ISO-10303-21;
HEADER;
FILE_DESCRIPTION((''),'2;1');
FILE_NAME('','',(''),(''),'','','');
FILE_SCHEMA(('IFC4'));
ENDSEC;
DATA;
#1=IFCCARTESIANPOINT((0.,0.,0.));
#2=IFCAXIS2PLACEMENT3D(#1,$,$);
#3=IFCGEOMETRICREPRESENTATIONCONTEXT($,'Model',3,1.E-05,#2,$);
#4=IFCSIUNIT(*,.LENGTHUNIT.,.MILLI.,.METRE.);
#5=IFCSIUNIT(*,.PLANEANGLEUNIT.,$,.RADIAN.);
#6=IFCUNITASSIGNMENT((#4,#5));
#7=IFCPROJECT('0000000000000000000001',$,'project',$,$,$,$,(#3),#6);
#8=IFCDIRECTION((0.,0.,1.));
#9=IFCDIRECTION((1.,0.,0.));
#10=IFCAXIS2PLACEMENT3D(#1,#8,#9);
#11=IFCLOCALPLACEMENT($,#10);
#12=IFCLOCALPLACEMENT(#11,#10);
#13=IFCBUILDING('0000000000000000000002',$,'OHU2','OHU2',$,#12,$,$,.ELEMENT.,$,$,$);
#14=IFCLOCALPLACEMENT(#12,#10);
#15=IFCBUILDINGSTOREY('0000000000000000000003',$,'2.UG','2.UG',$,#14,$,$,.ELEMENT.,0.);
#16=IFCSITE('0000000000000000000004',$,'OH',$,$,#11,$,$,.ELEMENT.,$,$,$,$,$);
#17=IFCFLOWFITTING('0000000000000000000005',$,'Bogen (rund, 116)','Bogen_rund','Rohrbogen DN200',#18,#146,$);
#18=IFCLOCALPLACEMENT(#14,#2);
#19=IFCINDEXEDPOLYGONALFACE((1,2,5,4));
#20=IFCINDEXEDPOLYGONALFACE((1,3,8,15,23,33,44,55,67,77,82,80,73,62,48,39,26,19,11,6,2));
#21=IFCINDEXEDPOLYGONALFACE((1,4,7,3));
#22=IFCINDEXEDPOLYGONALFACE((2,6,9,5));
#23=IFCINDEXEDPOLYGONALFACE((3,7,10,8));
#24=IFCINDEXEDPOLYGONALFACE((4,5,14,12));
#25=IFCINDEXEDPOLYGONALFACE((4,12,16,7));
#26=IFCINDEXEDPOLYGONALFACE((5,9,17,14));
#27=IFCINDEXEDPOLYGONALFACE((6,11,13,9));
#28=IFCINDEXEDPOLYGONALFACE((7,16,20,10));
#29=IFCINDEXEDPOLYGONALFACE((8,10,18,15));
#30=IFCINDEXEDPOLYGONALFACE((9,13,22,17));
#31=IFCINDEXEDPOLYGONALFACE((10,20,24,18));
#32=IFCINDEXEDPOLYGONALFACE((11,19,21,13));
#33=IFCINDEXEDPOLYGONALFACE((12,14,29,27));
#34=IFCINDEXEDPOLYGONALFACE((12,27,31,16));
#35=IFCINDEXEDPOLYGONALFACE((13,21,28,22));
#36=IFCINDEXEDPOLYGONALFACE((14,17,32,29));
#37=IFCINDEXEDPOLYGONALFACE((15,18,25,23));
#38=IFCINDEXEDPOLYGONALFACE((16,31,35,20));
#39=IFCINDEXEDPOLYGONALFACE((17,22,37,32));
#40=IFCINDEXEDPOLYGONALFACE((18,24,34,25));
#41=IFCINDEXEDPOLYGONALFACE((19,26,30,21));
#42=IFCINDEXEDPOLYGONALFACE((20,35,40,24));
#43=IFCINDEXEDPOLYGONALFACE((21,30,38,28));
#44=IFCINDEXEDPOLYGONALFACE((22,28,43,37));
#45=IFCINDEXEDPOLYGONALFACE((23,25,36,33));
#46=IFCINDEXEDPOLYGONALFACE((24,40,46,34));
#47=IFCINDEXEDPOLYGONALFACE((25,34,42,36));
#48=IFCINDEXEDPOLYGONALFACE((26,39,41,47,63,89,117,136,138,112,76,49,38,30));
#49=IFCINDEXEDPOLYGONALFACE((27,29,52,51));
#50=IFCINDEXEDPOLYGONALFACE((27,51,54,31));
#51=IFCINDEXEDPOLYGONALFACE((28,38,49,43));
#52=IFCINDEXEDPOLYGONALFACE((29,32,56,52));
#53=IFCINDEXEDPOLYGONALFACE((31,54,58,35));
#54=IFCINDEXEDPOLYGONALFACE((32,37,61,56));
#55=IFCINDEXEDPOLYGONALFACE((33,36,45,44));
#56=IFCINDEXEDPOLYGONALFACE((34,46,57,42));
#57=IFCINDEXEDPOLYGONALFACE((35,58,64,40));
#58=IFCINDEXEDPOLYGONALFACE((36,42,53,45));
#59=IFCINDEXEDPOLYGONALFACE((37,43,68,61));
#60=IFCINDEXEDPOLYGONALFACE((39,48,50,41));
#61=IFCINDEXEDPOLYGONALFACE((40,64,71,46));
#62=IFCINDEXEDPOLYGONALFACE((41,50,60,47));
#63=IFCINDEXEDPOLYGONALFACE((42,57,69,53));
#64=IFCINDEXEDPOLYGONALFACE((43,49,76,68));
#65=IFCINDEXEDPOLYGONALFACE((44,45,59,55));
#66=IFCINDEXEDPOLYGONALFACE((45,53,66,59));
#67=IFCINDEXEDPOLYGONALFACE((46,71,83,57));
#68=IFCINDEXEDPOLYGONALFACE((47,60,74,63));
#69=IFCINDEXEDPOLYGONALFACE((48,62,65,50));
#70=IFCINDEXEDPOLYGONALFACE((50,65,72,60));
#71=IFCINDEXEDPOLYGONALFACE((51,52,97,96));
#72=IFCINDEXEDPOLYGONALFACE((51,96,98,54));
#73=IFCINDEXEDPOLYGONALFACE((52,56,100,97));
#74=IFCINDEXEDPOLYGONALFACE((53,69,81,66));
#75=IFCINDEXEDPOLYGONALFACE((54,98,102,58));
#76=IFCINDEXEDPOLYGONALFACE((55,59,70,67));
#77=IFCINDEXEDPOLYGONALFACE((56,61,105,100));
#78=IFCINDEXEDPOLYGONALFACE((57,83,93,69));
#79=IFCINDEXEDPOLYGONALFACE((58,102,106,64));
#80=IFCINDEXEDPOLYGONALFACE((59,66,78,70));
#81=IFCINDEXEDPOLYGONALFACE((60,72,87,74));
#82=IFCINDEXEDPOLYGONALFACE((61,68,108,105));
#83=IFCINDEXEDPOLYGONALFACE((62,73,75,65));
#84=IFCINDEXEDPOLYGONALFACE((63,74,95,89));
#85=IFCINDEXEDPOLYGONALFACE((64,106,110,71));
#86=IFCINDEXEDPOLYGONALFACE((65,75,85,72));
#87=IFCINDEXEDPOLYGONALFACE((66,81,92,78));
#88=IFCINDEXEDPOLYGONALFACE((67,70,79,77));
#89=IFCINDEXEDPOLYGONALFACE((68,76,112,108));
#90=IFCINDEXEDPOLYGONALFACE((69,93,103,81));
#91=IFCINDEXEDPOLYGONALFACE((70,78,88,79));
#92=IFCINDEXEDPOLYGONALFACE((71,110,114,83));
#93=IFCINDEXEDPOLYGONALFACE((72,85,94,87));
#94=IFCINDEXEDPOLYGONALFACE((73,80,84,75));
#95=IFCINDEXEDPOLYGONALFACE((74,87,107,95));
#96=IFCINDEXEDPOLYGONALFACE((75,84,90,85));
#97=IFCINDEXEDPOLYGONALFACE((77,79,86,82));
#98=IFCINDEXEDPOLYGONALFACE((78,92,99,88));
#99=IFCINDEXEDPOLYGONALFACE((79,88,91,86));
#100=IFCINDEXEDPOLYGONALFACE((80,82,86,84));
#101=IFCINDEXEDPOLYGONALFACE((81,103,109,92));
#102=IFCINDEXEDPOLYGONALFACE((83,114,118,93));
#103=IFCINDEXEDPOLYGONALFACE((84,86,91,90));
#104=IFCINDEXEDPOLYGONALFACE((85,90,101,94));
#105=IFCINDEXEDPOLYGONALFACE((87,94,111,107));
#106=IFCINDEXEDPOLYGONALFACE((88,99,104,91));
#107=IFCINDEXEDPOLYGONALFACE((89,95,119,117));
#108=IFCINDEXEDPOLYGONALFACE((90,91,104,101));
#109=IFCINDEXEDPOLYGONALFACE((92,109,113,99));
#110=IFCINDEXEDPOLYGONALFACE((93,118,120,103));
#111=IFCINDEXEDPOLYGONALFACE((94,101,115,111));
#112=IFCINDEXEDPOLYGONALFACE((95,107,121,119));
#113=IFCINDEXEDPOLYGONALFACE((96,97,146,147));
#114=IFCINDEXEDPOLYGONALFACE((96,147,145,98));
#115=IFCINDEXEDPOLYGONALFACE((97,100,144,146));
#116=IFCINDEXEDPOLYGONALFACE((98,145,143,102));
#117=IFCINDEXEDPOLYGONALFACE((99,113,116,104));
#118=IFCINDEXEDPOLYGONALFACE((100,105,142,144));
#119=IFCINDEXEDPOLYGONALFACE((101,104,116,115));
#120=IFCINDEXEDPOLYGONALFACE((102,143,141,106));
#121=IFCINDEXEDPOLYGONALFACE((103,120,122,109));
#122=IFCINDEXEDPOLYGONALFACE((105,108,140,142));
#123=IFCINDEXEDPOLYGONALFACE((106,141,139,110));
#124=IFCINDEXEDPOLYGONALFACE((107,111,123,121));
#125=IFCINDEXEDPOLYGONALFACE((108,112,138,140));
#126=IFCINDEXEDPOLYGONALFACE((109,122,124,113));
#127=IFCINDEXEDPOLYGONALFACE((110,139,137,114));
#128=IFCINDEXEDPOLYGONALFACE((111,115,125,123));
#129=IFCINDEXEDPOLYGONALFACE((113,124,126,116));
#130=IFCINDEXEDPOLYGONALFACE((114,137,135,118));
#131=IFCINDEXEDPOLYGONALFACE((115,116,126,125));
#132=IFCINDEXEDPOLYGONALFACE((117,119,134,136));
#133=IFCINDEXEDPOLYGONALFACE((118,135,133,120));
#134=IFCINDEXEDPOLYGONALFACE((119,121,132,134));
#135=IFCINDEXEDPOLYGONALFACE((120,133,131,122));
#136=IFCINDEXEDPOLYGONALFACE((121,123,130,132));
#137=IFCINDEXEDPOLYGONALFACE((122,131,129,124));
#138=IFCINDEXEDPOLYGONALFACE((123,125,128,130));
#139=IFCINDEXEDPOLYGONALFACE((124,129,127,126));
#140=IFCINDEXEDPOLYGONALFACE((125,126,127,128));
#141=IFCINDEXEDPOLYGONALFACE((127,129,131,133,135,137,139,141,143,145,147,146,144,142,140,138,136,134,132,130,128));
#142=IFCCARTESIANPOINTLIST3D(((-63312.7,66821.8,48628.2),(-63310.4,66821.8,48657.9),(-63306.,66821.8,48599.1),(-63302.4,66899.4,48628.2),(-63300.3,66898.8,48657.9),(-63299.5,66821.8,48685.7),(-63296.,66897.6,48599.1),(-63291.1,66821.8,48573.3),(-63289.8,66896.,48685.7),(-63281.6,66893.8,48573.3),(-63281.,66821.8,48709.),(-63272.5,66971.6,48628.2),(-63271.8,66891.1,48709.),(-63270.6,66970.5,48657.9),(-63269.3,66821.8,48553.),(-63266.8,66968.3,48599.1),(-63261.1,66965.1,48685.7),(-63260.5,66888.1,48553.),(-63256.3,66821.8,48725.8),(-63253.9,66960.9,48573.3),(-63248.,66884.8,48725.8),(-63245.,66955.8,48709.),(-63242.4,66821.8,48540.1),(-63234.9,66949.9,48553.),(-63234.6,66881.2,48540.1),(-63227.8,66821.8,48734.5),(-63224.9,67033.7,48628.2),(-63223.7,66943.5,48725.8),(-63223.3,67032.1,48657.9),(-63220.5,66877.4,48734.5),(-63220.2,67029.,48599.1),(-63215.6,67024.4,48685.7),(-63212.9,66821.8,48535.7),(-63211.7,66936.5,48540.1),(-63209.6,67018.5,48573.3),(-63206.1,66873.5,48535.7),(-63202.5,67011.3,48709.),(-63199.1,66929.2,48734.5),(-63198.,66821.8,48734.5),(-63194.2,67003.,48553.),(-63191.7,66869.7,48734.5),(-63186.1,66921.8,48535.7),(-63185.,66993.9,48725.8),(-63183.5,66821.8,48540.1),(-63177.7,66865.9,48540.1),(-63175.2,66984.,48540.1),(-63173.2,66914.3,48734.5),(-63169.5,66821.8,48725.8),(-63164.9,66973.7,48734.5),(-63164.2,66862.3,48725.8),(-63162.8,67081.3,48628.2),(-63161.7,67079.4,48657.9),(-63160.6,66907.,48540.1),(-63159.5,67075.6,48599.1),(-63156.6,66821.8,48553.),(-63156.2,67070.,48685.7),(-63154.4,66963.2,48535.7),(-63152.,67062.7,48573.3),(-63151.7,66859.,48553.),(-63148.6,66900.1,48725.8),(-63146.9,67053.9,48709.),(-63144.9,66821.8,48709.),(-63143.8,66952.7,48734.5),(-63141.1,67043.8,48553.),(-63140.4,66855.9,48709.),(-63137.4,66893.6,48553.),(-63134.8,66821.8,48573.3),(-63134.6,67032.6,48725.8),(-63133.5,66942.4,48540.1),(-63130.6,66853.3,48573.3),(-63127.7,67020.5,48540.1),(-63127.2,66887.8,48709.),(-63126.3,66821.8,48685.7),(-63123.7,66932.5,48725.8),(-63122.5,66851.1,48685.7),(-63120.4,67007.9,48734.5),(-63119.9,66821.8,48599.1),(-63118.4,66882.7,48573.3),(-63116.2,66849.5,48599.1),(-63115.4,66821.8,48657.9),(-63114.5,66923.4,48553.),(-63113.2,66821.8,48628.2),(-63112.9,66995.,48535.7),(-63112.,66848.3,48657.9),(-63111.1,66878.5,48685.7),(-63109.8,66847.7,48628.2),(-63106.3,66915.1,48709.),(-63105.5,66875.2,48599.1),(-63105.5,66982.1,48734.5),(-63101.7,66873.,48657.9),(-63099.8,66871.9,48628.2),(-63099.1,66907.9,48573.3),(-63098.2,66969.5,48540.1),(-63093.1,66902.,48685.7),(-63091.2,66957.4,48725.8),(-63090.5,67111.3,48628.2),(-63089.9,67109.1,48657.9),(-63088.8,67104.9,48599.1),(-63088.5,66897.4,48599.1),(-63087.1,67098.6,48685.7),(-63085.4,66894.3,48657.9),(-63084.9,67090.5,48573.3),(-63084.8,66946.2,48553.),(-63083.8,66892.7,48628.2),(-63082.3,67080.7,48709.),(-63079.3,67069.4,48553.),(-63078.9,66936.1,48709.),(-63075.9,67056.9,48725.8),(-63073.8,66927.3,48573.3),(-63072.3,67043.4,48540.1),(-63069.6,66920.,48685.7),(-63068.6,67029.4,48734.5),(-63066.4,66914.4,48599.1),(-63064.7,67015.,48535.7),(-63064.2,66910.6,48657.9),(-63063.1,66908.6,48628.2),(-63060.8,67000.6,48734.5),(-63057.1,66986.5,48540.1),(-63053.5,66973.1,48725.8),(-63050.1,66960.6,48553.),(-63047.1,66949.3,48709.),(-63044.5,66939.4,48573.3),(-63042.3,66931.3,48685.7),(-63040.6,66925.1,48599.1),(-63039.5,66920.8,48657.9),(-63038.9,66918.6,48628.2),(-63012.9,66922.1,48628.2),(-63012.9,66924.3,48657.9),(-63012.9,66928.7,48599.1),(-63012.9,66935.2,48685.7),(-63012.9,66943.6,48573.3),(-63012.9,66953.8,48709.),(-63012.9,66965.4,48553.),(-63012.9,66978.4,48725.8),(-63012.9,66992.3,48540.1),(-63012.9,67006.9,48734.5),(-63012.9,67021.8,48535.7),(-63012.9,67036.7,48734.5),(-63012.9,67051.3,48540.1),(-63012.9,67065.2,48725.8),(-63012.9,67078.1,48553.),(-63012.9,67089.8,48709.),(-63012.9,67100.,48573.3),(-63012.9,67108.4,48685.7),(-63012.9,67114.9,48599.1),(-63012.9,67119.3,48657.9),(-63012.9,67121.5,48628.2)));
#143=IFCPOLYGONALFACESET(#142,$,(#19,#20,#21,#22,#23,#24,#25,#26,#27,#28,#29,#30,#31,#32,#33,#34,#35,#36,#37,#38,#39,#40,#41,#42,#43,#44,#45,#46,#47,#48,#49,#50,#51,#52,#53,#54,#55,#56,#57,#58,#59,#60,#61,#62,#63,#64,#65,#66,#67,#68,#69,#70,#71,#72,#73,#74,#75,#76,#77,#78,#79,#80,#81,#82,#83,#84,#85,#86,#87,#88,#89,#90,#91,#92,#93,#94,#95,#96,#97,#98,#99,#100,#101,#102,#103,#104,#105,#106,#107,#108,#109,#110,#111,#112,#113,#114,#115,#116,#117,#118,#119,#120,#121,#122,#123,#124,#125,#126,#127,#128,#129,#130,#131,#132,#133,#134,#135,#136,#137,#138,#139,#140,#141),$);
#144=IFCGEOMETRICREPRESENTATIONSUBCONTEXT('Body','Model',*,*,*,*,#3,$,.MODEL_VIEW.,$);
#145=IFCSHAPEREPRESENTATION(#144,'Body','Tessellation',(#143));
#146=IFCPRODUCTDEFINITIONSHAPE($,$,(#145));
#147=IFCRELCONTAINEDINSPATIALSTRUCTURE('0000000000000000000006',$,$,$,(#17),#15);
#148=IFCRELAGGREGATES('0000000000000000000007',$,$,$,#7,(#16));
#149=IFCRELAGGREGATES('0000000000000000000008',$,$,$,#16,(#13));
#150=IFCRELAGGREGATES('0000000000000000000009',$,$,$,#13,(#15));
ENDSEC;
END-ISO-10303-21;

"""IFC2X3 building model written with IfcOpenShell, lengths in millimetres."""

from ifc_helpers import new_model, entity, si_unit, frame, origin, origin_with_axes, place, context, subcontext, project, spatial, element, save


model = new_model("IFC2X3")

# Units and contexts
model_context = context("Model", 3, precision=1e-05, world=origin())
body_context = subcontext(model_context, "Body", "Model", "MODEL_VIEW")
ifc_project = project(units=[si_unit("LENGTHUNIT", "METRE", prefix="MILLI"), si_unit("PLANEANGLEUNIT", "RADIAN")], contexts=[model_context])

# Site, building, storey
site_placement = place(None, origin_with_axes())
site = spatial("IfcSite", under=ifc_project, at=site_placement, Name="OH", CompositionType="ELEMENT")
building_placement = place(site_placement, origin_with_axes())
building = spatial("IfcBuilding", under=site, at=building_placement, Name="OHU2", Description="OHU2", CompositionType="ELEMENT")
storey_placement = place(building_placement, origin_with_axes())
storey = spatial("IfcBuildingStorey", under=building, at=storey_placement, Name="2.UG", Description="2.UG", CompositionType="ELEMENT", Elevation=0.0)

# Flow fitting
flow_fitting_1_placement = place(storey_placement, frame((-63162.9, 66971.8, 48635.7), z_axis=(0.0, 0.0, 1.0), x_axis=(1.0, 0.0, 0.0)))
element("IfcFlowFitting", 1, at=flow_fitting_1_placement, inside=storey, Name="Bogen (rund, 116)", Description="Bogen_rund", ObjectType="Rohrbogen DN200", context=body_context, shape_type="SweptSolid", body=[
    entity("IfcRevolvedAreaSolid", entity("IfcCircleProfileDef", "AREA", None, entity("IfcAxis2Placement2D", entity("IfcCartesianPoint", [0.0, 0.0]), entity("IfcDirection", [1.0, 0.0])), 100.0), entity("IfcAxis2Placement3D", entity("IfcCartesianPoint", [150.0, 50.0, 0.0]), entity("IfcDirection", [-1.0, 0.0, 0.0]), entity("IfcDirection", [0.0, 0.0, -1.0])), entity("IfcAxis1Placement", entity("IfcCartesianPoint", [0.0, 200.0, 0.0]), entity("IfcDirection", [-1.0, 0.0, 0.0])), 1.570796),
])

save(model, "model.ifc")
